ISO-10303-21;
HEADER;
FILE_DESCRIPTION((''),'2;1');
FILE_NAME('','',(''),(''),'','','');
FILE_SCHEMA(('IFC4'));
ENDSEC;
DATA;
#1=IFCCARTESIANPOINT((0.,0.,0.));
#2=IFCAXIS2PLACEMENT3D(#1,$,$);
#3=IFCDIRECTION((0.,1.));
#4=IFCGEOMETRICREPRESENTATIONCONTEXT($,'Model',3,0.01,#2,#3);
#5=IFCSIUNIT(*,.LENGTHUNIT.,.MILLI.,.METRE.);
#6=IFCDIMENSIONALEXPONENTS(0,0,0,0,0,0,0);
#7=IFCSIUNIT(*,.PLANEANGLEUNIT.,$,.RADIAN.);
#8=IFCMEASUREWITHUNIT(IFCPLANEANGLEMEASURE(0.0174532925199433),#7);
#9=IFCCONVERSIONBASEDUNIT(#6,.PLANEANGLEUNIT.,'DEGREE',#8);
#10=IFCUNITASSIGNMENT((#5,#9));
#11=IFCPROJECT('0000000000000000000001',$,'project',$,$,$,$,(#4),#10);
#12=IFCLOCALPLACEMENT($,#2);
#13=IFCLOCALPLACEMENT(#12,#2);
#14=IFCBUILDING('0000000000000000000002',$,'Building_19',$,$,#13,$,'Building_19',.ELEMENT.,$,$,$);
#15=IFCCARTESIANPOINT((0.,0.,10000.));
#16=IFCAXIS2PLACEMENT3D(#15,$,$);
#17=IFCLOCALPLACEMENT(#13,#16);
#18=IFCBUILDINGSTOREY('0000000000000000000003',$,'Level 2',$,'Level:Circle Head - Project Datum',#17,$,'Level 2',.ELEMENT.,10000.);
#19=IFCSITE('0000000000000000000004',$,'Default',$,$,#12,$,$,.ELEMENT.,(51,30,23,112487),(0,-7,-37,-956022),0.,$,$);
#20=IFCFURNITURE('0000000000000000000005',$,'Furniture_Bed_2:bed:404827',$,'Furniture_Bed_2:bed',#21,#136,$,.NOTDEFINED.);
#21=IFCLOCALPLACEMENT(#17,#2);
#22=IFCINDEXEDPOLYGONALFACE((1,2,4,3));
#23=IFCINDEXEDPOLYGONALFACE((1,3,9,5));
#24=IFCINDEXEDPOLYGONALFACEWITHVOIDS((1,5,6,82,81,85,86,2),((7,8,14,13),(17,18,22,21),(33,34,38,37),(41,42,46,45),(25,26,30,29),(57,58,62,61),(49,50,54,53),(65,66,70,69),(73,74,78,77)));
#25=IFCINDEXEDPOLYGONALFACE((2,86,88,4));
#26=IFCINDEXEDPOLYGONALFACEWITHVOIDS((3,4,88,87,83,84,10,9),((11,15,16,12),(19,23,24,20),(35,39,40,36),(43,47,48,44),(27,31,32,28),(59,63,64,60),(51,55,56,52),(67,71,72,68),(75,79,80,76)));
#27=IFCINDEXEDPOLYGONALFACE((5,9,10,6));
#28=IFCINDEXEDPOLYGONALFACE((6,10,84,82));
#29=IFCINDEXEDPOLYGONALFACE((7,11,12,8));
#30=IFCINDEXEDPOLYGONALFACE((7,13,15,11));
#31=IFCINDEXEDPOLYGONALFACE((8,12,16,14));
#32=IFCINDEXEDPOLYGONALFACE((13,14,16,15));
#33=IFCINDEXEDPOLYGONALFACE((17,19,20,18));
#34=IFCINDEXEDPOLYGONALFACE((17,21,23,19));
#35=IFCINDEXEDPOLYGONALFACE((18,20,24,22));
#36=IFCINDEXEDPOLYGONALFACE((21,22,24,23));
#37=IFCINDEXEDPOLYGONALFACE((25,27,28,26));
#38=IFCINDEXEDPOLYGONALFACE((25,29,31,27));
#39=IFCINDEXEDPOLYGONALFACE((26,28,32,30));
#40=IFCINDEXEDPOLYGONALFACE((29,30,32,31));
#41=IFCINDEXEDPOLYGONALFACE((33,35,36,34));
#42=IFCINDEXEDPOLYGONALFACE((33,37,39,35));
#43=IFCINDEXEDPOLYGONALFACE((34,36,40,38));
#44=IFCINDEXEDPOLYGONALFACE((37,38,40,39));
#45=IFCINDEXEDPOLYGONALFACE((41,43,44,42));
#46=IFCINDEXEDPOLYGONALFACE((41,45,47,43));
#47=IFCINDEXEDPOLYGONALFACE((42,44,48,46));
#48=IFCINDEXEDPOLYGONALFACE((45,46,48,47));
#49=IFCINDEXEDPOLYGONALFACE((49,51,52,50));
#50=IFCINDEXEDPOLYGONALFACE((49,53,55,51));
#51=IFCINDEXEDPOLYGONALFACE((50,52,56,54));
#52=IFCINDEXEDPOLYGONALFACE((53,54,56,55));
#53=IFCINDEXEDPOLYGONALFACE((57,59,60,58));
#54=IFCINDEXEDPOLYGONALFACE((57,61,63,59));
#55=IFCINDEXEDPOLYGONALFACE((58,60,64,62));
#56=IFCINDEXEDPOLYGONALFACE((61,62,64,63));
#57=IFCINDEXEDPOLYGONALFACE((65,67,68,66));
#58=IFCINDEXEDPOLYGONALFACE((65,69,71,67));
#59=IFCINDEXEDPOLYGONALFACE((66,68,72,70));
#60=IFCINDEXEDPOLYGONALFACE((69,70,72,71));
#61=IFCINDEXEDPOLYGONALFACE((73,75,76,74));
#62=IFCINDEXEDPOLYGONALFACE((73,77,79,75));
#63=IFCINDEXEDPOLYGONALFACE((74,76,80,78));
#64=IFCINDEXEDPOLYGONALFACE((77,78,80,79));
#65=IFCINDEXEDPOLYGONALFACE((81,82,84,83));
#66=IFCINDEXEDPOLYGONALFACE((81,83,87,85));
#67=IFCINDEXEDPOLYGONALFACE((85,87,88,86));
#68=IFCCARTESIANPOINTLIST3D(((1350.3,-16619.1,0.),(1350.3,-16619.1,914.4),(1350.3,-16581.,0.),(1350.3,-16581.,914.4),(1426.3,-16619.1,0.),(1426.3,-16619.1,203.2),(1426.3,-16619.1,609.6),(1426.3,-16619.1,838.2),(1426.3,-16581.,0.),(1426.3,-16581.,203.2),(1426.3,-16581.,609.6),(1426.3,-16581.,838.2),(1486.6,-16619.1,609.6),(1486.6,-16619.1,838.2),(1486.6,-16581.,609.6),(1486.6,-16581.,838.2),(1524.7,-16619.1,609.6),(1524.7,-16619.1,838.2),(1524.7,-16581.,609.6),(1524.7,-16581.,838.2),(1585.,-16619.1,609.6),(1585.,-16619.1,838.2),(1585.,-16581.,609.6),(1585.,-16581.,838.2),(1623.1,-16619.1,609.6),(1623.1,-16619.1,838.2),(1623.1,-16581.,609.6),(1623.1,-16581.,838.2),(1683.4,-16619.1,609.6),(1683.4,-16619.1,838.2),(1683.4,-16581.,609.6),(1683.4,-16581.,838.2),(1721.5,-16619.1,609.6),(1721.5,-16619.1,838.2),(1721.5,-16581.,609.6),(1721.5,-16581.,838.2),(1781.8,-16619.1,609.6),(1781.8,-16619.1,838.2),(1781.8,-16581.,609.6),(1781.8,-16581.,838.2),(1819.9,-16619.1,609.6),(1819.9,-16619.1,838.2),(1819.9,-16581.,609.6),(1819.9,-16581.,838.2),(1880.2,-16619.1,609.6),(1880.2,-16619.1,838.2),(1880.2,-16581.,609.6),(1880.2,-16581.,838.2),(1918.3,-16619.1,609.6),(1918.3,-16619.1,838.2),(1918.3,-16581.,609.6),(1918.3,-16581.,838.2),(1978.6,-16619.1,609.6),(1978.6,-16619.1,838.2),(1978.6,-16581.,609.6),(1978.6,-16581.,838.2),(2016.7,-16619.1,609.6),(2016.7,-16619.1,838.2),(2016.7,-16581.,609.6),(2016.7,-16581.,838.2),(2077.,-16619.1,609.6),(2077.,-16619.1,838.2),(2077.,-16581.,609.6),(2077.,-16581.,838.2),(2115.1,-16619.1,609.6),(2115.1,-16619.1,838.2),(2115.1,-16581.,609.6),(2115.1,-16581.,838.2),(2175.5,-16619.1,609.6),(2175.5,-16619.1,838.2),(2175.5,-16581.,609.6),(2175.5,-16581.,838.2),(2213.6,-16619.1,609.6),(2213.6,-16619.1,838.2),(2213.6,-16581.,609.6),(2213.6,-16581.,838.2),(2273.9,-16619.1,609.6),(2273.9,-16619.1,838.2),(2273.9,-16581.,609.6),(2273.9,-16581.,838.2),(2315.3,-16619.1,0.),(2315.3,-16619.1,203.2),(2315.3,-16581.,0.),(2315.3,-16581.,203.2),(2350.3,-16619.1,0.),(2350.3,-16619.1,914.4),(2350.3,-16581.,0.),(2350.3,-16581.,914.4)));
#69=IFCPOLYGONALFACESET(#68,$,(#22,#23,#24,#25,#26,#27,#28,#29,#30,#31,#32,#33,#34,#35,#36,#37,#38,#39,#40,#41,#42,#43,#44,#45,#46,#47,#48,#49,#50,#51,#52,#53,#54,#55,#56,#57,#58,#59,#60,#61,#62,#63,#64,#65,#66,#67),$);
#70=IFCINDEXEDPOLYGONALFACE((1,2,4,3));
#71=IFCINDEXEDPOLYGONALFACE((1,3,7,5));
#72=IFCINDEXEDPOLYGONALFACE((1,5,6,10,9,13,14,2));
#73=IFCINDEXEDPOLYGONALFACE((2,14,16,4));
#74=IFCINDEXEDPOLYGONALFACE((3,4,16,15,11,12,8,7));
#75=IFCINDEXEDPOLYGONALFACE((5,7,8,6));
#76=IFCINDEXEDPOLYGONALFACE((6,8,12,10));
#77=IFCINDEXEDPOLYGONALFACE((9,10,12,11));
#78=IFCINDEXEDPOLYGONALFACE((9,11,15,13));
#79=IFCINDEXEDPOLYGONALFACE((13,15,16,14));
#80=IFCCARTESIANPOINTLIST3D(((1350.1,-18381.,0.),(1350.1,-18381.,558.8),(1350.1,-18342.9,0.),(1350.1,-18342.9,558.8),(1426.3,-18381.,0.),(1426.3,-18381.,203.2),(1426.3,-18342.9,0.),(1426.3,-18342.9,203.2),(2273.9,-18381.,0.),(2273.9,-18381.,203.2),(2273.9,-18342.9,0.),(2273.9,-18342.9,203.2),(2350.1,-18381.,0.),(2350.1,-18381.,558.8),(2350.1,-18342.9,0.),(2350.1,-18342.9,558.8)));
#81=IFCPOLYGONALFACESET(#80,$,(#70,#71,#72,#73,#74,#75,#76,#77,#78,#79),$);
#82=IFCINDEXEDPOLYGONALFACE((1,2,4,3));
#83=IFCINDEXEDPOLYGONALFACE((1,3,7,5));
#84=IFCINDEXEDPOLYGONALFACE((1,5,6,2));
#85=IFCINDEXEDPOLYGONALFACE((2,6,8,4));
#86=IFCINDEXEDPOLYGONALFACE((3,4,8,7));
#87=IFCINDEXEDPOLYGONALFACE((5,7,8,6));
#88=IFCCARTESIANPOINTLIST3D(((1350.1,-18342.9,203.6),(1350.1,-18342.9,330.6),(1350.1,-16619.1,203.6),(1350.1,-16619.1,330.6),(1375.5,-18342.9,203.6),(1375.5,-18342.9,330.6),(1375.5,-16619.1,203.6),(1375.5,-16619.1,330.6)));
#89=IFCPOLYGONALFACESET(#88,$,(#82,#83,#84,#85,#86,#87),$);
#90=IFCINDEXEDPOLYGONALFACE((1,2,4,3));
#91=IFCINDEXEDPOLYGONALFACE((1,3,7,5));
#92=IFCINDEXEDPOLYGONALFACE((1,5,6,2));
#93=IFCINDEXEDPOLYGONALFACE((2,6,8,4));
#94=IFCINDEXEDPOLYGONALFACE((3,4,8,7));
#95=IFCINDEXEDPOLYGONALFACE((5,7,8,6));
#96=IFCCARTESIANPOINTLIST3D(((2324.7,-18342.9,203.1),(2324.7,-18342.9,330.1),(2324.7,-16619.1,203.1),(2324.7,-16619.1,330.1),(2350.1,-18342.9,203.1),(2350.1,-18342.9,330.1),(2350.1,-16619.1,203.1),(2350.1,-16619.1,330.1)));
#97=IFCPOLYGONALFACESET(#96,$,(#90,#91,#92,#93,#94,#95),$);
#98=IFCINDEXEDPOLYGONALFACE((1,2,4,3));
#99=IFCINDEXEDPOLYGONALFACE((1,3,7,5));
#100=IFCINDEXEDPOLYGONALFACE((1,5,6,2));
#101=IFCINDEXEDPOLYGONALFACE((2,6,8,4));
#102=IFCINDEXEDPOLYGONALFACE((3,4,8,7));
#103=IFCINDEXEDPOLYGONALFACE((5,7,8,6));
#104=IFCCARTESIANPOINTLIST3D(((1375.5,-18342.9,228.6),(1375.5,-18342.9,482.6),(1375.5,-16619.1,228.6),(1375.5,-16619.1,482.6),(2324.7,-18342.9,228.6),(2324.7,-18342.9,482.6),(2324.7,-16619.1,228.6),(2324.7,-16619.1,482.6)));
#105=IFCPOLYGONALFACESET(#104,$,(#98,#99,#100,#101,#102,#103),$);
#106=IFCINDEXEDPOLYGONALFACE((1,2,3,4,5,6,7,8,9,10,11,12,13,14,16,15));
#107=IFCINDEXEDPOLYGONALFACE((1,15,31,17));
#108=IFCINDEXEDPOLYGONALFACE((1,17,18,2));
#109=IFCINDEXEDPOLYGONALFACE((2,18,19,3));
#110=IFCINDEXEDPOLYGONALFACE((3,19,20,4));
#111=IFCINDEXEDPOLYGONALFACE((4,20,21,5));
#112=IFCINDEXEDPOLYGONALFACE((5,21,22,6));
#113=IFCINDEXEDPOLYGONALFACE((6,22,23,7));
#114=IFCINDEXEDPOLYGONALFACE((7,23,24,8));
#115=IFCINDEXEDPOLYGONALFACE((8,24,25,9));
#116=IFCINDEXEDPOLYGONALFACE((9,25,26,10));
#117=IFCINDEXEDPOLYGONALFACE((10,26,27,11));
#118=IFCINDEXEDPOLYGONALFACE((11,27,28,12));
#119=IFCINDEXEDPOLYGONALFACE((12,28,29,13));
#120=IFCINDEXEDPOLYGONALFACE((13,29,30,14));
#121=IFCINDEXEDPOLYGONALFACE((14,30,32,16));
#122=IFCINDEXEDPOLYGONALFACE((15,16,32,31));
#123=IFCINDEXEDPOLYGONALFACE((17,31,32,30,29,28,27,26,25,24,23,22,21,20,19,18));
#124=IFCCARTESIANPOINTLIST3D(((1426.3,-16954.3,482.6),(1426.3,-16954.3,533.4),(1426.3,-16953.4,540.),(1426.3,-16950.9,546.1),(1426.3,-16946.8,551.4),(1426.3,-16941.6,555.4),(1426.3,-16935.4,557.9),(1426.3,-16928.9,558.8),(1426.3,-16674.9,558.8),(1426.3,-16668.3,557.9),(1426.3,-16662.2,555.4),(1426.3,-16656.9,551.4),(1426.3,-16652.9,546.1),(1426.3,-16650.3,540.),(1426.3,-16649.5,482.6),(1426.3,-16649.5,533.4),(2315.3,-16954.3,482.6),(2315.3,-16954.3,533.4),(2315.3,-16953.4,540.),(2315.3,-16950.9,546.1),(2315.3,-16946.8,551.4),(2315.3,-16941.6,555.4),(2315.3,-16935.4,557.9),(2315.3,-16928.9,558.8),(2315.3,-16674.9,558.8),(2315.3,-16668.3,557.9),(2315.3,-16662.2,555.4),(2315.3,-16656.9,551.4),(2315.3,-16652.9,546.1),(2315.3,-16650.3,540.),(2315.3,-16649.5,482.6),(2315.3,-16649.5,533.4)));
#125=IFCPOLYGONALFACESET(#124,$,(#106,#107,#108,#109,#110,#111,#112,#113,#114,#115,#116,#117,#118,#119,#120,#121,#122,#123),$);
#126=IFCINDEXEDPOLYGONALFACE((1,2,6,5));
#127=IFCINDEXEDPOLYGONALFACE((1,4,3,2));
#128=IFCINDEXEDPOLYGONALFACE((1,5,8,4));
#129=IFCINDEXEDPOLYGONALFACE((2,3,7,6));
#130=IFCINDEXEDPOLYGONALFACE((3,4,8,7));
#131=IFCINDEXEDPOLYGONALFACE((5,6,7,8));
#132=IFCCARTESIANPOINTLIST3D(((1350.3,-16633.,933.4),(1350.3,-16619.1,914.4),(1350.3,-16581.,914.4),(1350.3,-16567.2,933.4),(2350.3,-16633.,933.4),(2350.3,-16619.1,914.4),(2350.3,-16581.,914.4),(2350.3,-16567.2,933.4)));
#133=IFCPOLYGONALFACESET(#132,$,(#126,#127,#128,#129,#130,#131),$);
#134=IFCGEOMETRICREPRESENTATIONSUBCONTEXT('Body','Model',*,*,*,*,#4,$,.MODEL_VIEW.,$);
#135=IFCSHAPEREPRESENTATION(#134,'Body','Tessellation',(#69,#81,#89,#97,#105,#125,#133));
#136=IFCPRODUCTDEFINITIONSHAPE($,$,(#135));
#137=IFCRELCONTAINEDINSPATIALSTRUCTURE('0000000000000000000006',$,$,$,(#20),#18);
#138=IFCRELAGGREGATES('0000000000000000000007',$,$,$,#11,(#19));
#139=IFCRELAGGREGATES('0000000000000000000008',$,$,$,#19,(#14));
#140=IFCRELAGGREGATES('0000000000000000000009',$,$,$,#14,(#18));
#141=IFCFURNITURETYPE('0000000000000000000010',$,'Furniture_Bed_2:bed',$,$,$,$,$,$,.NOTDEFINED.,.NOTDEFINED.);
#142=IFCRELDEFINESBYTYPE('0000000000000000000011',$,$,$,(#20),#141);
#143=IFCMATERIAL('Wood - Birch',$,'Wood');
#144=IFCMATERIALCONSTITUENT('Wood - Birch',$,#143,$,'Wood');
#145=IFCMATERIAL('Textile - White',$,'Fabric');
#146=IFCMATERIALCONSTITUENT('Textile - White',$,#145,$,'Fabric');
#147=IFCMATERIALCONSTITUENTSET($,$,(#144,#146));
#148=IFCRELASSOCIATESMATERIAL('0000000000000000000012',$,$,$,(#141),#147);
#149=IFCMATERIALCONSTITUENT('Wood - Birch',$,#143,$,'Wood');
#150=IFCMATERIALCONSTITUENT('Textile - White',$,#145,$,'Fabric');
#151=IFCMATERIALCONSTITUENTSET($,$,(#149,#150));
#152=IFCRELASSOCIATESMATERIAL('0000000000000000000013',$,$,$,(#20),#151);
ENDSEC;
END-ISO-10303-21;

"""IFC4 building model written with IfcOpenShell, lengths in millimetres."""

from ifc_helpers import new_model, entity, si_unit, converted_unit, direction, frame, origin, place, context, subcontext, project, spatial, line, arc, indexed_curve, outline, extrude, source, transform, mapped, material, constituent, constituent_set, type_object, type_shapes, element, save


model = new_model("IFC4")

# Units and contexts
model_context = context("Model", 3, precision=0.01, world=origin(), true_north=direction((0.0, 1.0)))
body_context = subcontext(model_context, "Body", "Model", "MODEL_VIEW")
ifc_project = project(units=[si_unit("LENGTHUNIT", "METRE", prefix="MILLI"), converted_unit("PLANEANGLEUNIT", "DEGREE", entity("IfcPlaneAngleMeasure", 0.0174532925199433), si_unit("PLANEANGLEUNIT", "RADIAN"), dimensions=[0, 0, 0, 0, 0, 0, 0])], contexts=[model_context])

# Site, building, storey
site_placement = place(None, origin())
site = spatial("IfcSite", under=ifc_project, at=site_placement, Name="Default", CompositionType="ELEMENT", RefLatitude=(51, 30, 23, 112487), RefLongitude=(0, -7, -37, -956022), RefElevation=0.0)
building_placement = place(site_placement, origin())
building = spatial("IfcBuilding", under=site, at=building_placement, Name="Building_19", LongName="Building_19", CompositionType="ELEMENT")
storey_placement = place(building_placement, frame((0.0, 0.0, 10000.0)))
storey = spatial("IfcBuildingStorey", under=building, at=storey_placement, Name="Level 2", ObjectType="Level:Circle Head - Project Datum", LongName="Level 2", CompositionType="ELEMENT", Elevation=10000.0)

# Furniture
ifc_material_1 = material(Name="Wood - Birch", Category="Wood")
ifc_material_2 = material(Name="Textile - White", Category="Fabric")
ifc_constituent_1 = constituent(ifc_material_1, Name="Wood - Birch", Category="Wood")
ifc_constituent_2 = constituent(ifc_material_2, Name="Textile - White", Category="Fabric")
ifc_constituent_set_1 = constituent_set(constituents=[ifc_constituent_1, ifc_constituent_2])
furniture_type_1 = type_object("IfcFurnitureType", Name="Furniture_Bed_2:bed", AssemblyPlace="NOTDEFINED", PredefinedType="NOTDEFINED", material=ifc_constituent_set_1)
shared_shape_1 = source(origin(), body_context, "Body", "SweptSolid", [
    extrude(outline(indexed_curve([(-635.0, -489.8), (279.4, -489.8), (279.4, -454.7), (76.2, -454.7), (76.2, 434.3), (279.4, 434.3), (279.4, 510.3), (-635.0, 510.3), (-635.0, -489.8)], self_intersect=False), holes=[indexed_curve([(-558.8, 374.0), (-558.8, 434.3), (-330.2, 434.3), (-330.2, 374.0), (-558.8, 374.0)], self_intersect=False), indexed_curve([(-558.8, 275.5), (-558.8, 335.9), (-330.2, 335.9), (-330.2, 275.5), (-558.8, 275.5)], self_intersect=False), indexed_curve([(-558.8, 177.1), (-558.8, 237.4), (-330.2, 237.4), (-330.2, 177.1), (-558.8, 177.1)], self_intersect=False), indexed_curve([(-558.8, 78.7), (-558.8, 139.0), (-330.2, 139.0), (-330.2, 78.7), (-558.8, 78.7)], self_intersect=False), indexed_curve([(-558.8, -118.1), (-558.8, -57.8), (-330.2, -57.8), (-330.2, -118.1), (-558.8, -118.1)], self_intersect=False), indexed_curve([(-558.8, -216.5), (-558.8, -156.2), (-330.2, -156.2), (-330.2, -216.5), (-558.8, -216.5)], self_intersect=False), indexed_curve([(-558.8, -314.9), (-558.8, -254.6), (-330.2, -254.6), (-330.2, -314.9), (-558.8, -314.9)], self_intersect=False), indexed_curve([(-558.8, -413.3), (-558.8, -353.0), (-330.2, -353.0), (-330.2, -413.3), (-558.8, -413.3)], self_intersect=False), indexed_curve([(-558.8, -19.7), (-558.8, 40.6), (-330.2, 40.6), (-330.2, -19.7), (-558.8, -19.7)], self_intersect=False)]), frame((-8.6, -38.1, 279.4), z_axis=(0.0, 1.0, 0.0), x_axis=(0.0, 0.0, -1.0)), (0.0, 0.0, 1.0), 38.1),
    extrude(outline(indexed_curve([(423.8, -190.5), (500.0, -190.5), (500.0, 368.3), (-500.0, 368.3), (-500.0, -190.5), (-423.8, -190.5), (-423.8, 12.7), (423.8, 12.7), (423.8, -190.5)], self_intersect=False)), frame((-19.1, -1800.0, 190.5), z_axis=(0.0, 1.0, 0.0), x_axis=(-1.0, 0.0, 0.0)), (0.0, 0.0, 1.0), 38.1),
    extrude(outline(indexed_curve([(-12.7, -861.9), (12.7, -861.9), (12.7, 861.9), (-12.7, 861.9), (-12.7, -861.9)], self_intersect=False)), frame((-506.4, -900.0, 203.6)), (0.0, 0.0, 1.0), 127.0),
    extrude(outline(indexed_curve([(-12.7, -861.9), (12.7, -861.9), (12.7, 861.9), (-12.7, 861.9), (-12.7, -861.9)], self_intersect=False)), frame((468.2, -900.0, 203.1)), (0.0, 0.0, 1.0), 127.0),
    extrude(outline(indexed_curve([(-474.6, -861.9), (474.6, -861.9), (474.6, 861.9), (-474.6, 861.9), (-474.6, -861.9)], self_intersect=False)), frame((-19.0, -900.0, 228.6), z_axis=(0.0, 0.0, 1.0), x_axis=(-1.0, 0.0, 0.0)), (0.0, 0.0, 1.0), 254.0),
    extrude(outline(indexed_curve([(-152.4, -42.3), (152.4, -42.3), (152.4, 8.5), (145.0, 26.4), (127.0, 33.9), (-127.0, 33.9), (-145.0, 26.4), (-152.4, 8.5)], segments=[line(1, 2, 3), arc(3, 4, 5), line(5, 6), arc(6, 7, 8), line(8, 1)], self_intersect=False)), frame((-442.9, -220.8, 524.9), z_axis=(1.0, 0.0, 0.0), x_axis=(0.0, 1.0, 0.0)), (0.0, 0.0, 1.0), 889.0),
    extrude(outline(indexed_curve([(-19.1, -9.5), (19.0, -9.5), (32.9, 9.5), (-32.9, 9.5), (-19.1, -9.5)], self_intersect=False)), frame((-518.8, -19.0, 923.9), z_axis=(1.0, 0.0, 0.0), x_axis=(0.0, 1.0, 0.0)), (0.0, 0.0, 1.0), 1000.1),
])
type_shapes(furniture_type_1, [shared_shape_1])
ifc_constituent_3 = constituent(ifc_material_1, Name="Wood - Birch", Category="Wood")
ifc_constituent_4 = constituent(ifc_material_2, Name="Textile - White", Category="Fabric")
ifc_constituent_set_2 = constituent_set(constituents=[ifc_constituent_3, ifc_constituent_4])
furniture_1_placement = place(storey_placement, frame((1869.1, -16581.0, 0.0)))
element("IfcFurniture", 1, at=furniture_1_placement, inside=storey, type_object=furniture_type_1, material=ifc_constituent_set_2, Name="Furniture_Bed_2:bed:404827", ObjectType="Furniture_Bed_2:bed", PredefinedType="NOTDEFINED", context=body_context, shape_type="MappedRepresentation", body=[
    mapped(shared_shape_1, transform((0.0, 0.0, 0.0), scale=1.0)),
])

save(model, "model.ifc")
